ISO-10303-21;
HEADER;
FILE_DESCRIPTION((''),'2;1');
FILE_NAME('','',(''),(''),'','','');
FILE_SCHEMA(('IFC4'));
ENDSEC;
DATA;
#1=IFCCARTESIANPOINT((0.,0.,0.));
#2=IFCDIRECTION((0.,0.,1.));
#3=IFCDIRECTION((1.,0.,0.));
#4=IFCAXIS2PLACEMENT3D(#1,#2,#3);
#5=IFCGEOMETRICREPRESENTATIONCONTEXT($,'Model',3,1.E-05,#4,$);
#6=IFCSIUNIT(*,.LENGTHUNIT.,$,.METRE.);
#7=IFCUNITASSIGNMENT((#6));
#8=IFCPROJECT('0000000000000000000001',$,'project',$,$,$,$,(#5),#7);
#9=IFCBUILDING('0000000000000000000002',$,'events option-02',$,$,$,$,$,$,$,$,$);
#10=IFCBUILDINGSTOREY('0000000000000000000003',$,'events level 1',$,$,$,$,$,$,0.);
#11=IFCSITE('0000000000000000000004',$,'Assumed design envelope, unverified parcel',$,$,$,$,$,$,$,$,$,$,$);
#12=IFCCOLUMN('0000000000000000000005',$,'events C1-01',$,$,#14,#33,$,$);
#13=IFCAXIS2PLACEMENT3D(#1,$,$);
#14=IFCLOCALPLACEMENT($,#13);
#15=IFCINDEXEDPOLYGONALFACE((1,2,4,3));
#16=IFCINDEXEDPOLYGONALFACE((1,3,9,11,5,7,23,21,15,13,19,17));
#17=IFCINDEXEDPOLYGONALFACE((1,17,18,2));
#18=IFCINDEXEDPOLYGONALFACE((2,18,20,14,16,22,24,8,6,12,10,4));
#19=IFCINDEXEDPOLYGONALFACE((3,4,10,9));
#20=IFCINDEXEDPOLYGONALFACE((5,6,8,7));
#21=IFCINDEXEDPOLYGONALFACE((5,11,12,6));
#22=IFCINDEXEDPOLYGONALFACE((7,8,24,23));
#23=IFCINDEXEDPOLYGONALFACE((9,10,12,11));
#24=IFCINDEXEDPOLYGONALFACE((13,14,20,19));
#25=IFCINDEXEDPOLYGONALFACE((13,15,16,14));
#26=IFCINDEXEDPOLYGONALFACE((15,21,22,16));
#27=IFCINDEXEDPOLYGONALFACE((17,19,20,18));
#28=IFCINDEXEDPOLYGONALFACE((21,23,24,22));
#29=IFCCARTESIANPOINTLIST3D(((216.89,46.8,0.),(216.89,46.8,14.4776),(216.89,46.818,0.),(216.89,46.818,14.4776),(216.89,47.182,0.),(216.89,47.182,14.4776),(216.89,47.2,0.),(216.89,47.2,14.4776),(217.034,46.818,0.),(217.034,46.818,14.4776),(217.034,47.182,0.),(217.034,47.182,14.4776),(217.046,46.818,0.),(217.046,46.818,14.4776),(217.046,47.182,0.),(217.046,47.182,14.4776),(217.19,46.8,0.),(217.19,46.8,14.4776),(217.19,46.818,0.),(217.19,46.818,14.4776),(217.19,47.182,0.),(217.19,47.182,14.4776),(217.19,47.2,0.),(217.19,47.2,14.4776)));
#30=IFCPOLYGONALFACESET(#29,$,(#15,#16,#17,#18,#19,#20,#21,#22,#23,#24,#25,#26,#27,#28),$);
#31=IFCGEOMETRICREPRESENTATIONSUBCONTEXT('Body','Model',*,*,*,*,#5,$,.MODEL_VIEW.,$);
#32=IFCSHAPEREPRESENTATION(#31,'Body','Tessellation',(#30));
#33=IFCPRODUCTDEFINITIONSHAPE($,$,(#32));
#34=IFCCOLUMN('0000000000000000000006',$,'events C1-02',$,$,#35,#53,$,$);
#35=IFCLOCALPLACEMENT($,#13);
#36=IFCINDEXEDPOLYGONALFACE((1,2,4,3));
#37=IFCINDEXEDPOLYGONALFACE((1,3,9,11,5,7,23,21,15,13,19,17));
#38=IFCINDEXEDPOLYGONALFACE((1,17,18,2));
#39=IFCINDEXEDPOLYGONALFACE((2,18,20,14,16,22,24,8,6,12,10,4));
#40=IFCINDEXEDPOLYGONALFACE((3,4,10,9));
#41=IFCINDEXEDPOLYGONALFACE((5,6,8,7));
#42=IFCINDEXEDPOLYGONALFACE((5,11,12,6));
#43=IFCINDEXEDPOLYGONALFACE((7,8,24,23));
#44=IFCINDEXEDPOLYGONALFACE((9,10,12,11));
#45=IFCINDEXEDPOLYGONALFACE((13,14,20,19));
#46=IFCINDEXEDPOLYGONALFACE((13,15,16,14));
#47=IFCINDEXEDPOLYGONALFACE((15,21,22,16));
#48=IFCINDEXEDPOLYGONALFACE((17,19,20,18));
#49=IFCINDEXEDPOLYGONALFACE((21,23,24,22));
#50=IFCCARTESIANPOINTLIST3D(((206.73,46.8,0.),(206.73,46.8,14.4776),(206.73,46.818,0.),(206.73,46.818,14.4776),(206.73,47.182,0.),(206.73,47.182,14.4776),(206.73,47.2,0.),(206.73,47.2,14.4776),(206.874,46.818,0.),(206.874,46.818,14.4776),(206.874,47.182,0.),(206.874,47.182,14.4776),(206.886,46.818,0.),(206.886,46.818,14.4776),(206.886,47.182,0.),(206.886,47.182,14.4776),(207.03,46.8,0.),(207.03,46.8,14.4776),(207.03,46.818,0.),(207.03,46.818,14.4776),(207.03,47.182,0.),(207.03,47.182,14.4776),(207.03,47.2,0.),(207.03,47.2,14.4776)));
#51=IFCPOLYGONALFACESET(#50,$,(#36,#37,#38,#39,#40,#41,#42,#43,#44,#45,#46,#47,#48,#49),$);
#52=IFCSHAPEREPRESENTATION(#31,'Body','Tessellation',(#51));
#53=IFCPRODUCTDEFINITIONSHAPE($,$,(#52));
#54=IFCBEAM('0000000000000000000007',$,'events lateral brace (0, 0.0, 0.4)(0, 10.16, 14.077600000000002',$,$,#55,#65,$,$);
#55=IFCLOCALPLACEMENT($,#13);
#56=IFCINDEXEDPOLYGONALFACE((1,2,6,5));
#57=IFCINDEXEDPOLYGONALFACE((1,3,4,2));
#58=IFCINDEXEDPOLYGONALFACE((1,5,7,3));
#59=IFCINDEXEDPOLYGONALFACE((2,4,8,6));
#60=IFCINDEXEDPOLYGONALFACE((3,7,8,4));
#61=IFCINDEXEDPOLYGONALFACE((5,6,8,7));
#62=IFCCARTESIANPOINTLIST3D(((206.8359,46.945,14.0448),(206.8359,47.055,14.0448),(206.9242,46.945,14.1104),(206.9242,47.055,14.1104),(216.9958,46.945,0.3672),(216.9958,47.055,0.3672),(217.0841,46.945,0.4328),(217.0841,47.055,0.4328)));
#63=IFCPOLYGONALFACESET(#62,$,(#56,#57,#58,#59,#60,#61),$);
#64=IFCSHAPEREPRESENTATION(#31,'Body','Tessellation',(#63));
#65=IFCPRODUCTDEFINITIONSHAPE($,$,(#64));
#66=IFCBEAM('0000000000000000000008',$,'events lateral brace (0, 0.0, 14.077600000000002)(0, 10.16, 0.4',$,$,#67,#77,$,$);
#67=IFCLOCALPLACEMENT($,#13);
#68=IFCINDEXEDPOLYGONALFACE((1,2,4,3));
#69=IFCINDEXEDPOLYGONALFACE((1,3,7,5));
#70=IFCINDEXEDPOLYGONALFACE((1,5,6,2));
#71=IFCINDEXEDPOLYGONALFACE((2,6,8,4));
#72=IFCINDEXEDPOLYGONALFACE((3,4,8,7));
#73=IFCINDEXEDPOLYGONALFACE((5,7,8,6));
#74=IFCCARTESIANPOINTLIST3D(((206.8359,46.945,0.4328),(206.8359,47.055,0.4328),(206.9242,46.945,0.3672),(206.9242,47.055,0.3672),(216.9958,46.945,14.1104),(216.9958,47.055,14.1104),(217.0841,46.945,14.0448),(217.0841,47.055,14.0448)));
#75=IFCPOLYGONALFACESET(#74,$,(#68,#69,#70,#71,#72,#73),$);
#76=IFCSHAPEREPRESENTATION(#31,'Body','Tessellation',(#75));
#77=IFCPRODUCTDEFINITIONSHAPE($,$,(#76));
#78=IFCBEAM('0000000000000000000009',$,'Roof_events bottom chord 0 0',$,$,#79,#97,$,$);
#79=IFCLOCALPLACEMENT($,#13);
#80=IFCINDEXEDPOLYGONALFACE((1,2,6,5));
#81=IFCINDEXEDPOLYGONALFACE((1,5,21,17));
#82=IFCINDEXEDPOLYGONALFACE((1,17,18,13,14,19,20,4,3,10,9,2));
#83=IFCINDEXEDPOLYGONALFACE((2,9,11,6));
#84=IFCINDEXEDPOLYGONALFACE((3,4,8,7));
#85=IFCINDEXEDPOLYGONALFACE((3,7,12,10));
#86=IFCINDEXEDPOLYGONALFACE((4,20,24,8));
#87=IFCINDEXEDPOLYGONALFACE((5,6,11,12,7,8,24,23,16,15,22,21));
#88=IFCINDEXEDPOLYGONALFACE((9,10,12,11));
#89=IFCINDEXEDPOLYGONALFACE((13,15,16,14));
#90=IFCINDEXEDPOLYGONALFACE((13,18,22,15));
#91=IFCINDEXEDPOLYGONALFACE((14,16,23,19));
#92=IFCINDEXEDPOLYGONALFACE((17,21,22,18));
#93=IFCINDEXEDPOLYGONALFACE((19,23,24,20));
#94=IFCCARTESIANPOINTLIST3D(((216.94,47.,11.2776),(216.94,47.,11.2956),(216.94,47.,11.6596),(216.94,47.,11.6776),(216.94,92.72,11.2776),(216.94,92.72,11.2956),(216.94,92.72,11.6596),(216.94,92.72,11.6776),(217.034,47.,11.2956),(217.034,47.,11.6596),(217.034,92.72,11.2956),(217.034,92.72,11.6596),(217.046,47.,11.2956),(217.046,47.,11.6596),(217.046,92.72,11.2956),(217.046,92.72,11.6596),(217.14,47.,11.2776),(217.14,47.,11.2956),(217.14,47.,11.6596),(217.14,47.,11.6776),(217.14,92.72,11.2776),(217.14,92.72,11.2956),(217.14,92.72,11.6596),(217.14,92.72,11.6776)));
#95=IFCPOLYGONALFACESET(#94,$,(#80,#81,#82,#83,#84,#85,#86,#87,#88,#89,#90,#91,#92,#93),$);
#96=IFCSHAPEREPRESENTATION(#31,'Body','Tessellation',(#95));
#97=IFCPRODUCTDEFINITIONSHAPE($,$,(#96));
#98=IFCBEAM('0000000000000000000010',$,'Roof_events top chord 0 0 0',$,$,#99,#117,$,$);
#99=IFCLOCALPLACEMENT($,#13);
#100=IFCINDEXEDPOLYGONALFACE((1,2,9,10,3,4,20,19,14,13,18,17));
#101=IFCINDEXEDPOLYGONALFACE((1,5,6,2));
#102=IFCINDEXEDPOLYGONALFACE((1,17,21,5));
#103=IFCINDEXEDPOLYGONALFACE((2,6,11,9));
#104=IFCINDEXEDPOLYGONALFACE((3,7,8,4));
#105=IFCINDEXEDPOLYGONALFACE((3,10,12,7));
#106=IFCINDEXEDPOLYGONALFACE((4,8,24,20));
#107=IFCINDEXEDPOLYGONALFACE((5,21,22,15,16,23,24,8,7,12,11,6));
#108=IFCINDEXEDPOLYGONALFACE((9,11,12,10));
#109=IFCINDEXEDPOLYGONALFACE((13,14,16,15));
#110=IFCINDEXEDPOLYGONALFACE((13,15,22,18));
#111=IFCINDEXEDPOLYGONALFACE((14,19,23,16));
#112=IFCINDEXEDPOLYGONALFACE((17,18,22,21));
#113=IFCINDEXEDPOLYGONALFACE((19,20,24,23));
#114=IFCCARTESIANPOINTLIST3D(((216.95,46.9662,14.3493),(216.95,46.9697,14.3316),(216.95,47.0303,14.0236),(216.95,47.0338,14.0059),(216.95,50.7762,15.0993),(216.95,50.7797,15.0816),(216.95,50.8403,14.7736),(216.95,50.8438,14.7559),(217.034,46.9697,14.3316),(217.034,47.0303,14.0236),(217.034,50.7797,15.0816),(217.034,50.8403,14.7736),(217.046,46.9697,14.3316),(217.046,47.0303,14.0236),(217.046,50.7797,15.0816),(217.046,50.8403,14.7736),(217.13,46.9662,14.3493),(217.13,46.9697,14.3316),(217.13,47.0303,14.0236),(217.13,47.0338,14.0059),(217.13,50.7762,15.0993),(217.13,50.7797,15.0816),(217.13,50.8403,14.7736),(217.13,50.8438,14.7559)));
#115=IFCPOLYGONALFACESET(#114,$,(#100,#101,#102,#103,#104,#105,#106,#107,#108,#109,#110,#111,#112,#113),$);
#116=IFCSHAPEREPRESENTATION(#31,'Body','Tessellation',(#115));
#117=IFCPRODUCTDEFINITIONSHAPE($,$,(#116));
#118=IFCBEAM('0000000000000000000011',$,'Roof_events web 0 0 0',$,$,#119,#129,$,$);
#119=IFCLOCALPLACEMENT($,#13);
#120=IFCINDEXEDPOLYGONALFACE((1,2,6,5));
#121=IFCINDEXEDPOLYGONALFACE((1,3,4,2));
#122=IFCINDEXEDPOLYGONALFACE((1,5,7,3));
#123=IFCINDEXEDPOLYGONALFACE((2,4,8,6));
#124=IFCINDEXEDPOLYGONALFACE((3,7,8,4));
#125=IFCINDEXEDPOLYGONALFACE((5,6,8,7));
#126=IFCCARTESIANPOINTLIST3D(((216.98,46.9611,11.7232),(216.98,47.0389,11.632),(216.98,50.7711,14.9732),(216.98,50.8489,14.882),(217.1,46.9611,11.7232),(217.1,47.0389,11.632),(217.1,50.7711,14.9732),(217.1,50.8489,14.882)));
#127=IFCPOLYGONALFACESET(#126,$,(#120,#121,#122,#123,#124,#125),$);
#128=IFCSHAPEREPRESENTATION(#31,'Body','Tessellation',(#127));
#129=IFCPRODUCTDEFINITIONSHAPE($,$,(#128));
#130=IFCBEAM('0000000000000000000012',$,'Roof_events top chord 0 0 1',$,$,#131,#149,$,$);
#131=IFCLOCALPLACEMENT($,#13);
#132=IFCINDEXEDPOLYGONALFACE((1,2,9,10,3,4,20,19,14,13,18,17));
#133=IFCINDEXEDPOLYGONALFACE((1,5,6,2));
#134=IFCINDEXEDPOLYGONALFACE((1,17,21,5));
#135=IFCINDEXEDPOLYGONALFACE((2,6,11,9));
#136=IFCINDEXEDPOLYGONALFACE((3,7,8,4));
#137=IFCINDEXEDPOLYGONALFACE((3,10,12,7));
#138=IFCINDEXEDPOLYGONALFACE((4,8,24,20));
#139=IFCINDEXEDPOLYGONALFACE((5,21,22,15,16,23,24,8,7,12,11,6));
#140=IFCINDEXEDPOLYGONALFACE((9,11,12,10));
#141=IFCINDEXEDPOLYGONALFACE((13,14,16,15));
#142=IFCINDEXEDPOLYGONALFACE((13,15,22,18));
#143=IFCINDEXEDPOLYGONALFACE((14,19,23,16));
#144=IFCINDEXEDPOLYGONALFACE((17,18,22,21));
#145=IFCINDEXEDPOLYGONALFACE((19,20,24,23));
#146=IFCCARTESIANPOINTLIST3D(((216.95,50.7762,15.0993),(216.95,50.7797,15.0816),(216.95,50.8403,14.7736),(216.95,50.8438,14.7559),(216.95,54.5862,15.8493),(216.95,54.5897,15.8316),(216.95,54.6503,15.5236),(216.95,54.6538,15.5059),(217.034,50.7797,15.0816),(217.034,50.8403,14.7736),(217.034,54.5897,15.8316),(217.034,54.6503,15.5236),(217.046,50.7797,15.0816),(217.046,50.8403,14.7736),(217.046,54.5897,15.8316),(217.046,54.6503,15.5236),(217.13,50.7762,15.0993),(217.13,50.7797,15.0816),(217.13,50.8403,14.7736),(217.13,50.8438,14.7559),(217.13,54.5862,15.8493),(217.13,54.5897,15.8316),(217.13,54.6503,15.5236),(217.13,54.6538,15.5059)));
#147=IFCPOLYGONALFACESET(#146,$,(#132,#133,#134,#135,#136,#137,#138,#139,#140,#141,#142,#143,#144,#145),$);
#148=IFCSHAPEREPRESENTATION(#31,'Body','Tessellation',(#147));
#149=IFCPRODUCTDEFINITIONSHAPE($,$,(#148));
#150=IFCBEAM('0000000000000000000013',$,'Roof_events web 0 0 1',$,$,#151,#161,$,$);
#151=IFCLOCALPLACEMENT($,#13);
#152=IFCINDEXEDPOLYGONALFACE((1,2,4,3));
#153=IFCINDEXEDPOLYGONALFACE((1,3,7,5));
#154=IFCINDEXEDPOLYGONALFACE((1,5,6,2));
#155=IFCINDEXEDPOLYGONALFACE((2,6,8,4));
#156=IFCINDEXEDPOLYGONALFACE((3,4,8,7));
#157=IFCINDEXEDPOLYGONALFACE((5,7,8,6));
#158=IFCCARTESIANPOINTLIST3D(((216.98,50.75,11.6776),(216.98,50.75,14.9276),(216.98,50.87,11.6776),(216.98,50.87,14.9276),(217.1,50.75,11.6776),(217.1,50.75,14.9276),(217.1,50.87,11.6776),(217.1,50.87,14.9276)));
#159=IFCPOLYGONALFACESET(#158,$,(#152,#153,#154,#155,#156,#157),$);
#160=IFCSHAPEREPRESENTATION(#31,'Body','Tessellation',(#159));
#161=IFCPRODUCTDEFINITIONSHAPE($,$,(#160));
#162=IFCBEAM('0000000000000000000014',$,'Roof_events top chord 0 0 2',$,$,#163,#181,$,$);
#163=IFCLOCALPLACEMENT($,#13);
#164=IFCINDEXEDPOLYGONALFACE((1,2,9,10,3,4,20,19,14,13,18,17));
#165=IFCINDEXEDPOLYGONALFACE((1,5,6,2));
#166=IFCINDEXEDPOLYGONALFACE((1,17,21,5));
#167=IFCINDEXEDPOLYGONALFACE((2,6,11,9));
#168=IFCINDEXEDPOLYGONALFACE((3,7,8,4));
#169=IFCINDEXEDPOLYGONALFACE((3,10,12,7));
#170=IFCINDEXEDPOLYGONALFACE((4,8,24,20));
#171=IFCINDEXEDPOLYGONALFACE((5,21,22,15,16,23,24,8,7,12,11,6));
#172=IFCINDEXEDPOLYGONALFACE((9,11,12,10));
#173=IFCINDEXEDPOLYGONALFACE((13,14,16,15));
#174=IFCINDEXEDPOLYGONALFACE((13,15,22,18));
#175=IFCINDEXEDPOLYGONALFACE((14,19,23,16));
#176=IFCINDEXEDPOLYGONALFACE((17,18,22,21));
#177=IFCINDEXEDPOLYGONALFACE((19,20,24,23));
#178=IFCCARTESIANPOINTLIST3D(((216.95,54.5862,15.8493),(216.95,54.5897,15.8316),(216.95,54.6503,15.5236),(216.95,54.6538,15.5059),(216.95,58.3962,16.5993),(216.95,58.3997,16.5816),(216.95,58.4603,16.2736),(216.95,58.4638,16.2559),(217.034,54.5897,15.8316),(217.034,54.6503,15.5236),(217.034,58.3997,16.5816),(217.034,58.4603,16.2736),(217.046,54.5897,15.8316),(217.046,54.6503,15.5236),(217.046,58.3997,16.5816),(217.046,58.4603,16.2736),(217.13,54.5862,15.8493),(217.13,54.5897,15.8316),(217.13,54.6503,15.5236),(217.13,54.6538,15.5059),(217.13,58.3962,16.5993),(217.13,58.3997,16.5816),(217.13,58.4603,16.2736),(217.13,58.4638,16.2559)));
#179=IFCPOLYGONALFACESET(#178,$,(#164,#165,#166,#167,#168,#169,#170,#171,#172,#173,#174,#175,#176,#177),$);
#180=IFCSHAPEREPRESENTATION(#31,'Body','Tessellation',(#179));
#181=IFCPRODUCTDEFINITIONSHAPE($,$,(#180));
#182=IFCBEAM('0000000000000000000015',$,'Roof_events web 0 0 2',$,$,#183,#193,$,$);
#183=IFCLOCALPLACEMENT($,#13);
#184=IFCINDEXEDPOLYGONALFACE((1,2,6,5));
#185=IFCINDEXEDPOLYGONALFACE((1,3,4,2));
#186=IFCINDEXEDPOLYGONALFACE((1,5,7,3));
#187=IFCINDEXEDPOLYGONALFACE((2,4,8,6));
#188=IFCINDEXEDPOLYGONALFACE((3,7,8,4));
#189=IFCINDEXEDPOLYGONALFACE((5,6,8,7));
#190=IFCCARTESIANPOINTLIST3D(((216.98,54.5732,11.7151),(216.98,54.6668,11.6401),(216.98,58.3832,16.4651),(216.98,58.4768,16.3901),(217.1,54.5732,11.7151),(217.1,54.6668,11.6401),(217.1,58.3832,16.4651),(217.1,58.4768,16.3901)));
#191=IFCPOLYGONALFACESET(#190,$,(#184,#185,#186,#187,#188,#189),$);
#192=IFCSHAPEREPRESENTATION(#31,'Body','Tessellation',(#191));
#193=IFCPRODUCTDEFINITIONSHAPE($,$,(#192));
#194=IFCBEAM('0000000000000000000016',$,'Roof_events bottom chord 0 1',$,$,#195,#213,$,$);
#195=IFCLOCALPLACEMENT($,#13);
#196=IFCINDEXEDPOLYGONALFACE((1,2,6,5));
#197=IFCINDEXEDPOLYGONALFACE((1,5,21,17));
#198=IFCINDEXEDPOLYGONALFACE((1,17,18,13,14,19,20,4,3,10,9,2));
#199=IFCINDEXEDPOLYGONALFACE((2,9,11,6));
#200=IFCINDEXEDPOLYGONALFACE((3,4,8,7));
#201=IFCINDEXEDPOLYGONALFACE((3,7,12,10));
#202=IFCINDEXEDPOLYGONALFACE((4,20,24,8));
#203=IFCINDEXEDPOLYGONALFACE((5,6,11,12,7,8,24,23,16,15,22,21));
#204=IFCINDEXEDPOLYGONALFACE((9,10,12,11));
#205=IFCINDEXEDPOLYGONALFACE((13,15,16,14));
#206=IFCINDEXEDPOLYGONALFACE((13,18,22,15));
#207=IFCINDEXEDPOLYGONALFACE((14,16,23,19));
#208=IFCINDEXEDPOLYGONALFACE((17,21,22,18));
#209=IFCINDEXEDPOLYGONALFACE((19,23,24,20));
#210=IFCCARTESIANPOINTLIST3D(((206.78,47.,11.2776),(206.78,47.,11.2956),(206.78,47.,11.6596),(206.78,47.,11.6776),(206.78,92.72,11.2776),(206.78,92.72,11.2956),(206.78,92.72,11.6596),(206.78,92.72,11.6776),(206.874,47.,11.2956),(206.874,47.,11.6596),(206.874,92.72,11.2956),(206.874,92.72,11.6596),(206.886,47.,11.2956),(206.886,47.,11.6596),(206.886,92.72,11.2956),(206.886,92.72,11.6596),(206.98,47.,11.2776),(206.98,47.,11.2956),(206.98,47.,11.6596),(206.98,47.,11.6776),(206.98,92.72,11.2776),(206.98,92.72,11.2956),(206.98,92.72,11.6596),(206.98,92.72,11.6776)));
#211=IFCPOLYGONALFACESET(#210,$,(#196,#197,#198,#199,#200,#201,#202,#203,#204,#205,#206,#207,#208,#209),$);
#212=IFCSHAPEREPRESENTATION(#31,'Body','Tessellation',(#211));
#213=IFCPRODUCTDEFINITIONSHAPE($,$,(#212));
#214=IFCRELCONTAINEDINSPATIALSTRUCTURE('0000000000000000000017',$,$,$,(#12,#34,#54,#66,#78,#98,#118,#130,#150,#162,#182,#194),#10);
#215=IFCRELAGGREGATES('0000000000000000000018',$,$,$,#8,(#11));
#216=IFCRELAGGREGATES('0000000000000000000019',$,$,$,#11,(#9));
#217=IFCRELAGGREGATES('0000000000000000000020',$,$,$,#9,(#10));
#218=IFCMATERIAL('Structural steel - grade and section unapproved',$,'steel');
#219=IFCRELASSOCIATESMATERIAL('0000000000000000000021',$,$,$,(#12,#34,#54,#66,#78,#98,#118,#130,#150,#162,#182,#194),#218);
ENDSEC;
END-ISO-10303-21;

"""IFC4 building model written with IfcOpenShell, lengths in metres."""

from ifc_helpers import new_model, si_unit, frame, origin_with_axes, place, context, subcontext, project, spatial, rectangle, i_section, extrude, material, element, save


model = new_model("IFC4")

# Units and contexts
model_context = context("Model", 3, precision=1e-05, world=origin_with_axes())
body_context = subcontext(model_context, "Body", "Model", "MODEL_VIEW")
ifc_project = project(units=[si_unit("LENGTHUNIT", "METRE")], contexts=[model_context])

# Site, building, storey
site = spatial("IfcSite", under=ifc_project, Name="Assumed design envelope, unverified parcel")
building = spatial("IfcBuilding", under=site, Name="events option-02")
storey = spatial("IfcBuildingStorey", under=building, Name="events level 1", Elevation=0.0)

# Columns
ifc_material_1 = material(Name="Structural steel - grade and section unapproved", Category="steel")
for number, where, z_axis, x_axis, name in (
    (1, (217.04, 47.0, 0.0), (0.0, 0.0, 1.0), (-1.0, 0.0, 0.0), "events C1-01"),
    (2, (206.88, 47.0, 0.0), (0.0, 0.0, 1.0), (-1.0, 0.0, 0.0), "events C1-02"),
):
    element("IfcColumn", number, at=place(None, frame(where, z_axis=z_axis, x_axis=x_axis)), inside=storey, material=ifc_material_1, Name=name, context=body_context, shape_type="SweptSolid", body=[
        extrude(i_section(OverallWidth=0.3, OverallDepth=0.4, WebThickness=0.012, FlangeThickness=0.018, FilletRadius=0.0), origin_with_axes(), (0.0, 0.0, 1.0), 14.4776),
    ])

# Beams
for number, where, z_axis, x_axis, name in (
    (3, (217.04, 47.0, 0.4), (-0.596305, 0.0, 0.802758), (0.0, -1.0, 0.0), "events lateral brace (0, 0.0, 0.4)(0, 10.16, 14.077600000000002"),
    (4, (217.04, 47.0, 14.0776), (-0.596305, 0.0, -0.802758), (0.0, -1.0, 0.0), "events lateral brace (0, 0.0, 14.077600000000002)(0, 10.16, 0.4"),
):
    element("IfcBeam", number, at=place(None, frame(where, z_axis=z_axis, x_axis=x_axis)), inside=storey, material=ifc_material_1, Name=name, context=body_context, shape_type="SweptSolid", body=[
        extrude(rectangle(XDim=0.11, YDim=0.11), origin_with_axes(), (0.0, 0.0, 1.0), 17.0383),
    ])
beam_1_placement = place(None, frame((217.04, 47.0, 11.4776), z_axis=(0.0, 1.0, 0.0), x_axis=(-1.0, 0.0, 0.0)))
element("IfcBeam", 5, at=beam_1_placement, inside=storey, material=ifc_material_1, Name="Roof_events bottom chord 0 0", context=body_context, shape_type="SweptSolid", body=[
    extrude(i_section(OverallWidth=0.2, OverallDepth=0.4, WebThickness=0.012, FlangeThickness=0.018, FilletRadius=0.0), origin_with_axes(), (0.0, 0.0, 1.0), 45.72),
])
beam_2_placement = place(None, frame((217.04, 47.0, 14.1776), z_axis=(0.0, 0.98117, 0.193144), x_axis=(-1.0, 0.0, 0.0)))
element("IfcBeam", 6, at=beam_2_placement, inside=storey, material=ifc_material_1, Name="Roof_events top chord 0 0 0", context=body_context, shape_type="SweptSolid", body=[
    extrude(i_section(OverallWidth=0.18, OverallDepth=0.35, WebThickness=0.012, FlangeThickness=0.018, FilletRadius=0.0), origin_with_axes(), (0.0, 0.0, 1.0), 3.8831),
])
beam_3_placement = place(None, frame((217.04, 47.0, 11.6776), z_axis=(0.0, 0.760805, 0.64898), x_axis=(-1.0, 0.0, 0.0)))
element("IfcBeam", 7, at=beam_3_placement, inside=storey, material=ifc_material_1, Name="Roof_events web 0 0 0", context=body_context, shape_type="SweptSolid", body=[
    extrude(rectangle(XDim=0.12, YDim=0.12), origin_with_axes(), (0.0, 0.0, 1.0), 5.0079),
])
beam_4_placement = place(None, frame((217.04, 50.81, 14.9276), z_axis=(0.0, 0.98117, 0.193144), x_axis=(-1.0, 0.0, 0.0)))
element("IfcBeam", 8, at=beam_4_placement, inside=storey, material=ifc_material_1, Name="Roof_events top chord 0 0 1", context=body_context, shape_type="SweptSolid", body=[
    extrude(i_section(OverallWidth=0.18, OverallDepth=0.35, WebThickness=0.012, FlangeThickness=0.018, FilletRadius=0.0), origin_with_axes(), (0.0, 0.0, 1.0), 3.8831),
])
beam_5_placement = place(None, frame((217.04, 50.81, 11.6776), z_axis=(0.0, 0.0, 1.0), x_axis=(-1.0, 0.0, 0.0)))
element("IfcBeam", 9, at=beam_5_placement, inside=storey, material=ifc_material_1, Name="Roof_events web 0 0 1", context=body_context, shape_type="SweptSolid", body=[
    extrude(rectangle(XDim=0.12, YDim=0.12), origin_with_axes(), (0.0, 0.0, 1.0), 3.25),
])
beam_6_placement = place(None, frame((217.04, 54.62, 15.6776), z_axis=(0.0, 0.98117, 0.193144), x_axis=(-1.0, 0.0, 0.0)))
element("IfcBeam", 10, at=beam_6_placement, inside=storey, material=ifc_material_1, Name="Roof_events top chord 0 0 2", context=body_context, shape_type="SweptSolid", body=[
    extrude(i_section(OverallWidth=0.18, OverallDepth=0.35, WebThickness=0.012, FlangeThickness=0.018, FilletRadius=0.0), origin_with_axes(), (0.0, 0.0, 1.0), 3.8831),
])
beam_7_placement = place(None, frame((217.04, 54.62, 11.6776), z_axis=(0.0, 0.625696, 0.780067), x_axis=(-1.0, 0.0, 0.0)))
element("IfcBeam", 11, at=beam_7_placement, inside=storey, material=ifc_material_1, Name="Roof_events web 0 0 2", context=body_context, shape_type="SweptSolid", body=[
    extrude(rectangle(XDim=0.12, YDim=0.12), origin_with_axes(), (0.0, 0.0, 1.0), 6.0892),
])
beam_8_placement = place(None, frame((206.88, 47.0, 11.4776), z_axis=(0.0, 1.0, 0.0), x_axis=(-1.0, 0.0, 0.0)))
element("IfcBeam", 12, at=beam_8_placement, inside=storey, material=ifc_material_1, Name="Roof_events bottom chord 0 1", context=body_context, shape_type="SweptSolid", body=[
    extrude(i_section(OverallWidth=0.2, OverallDepth=0.4, WebThickness=0.012, FlangeThickness=0.018, FilletRadius=0.0), origin_with_axes(), (0.0, 0.0, 1.0), 45.72),
])

save(model, "model.ifc")
